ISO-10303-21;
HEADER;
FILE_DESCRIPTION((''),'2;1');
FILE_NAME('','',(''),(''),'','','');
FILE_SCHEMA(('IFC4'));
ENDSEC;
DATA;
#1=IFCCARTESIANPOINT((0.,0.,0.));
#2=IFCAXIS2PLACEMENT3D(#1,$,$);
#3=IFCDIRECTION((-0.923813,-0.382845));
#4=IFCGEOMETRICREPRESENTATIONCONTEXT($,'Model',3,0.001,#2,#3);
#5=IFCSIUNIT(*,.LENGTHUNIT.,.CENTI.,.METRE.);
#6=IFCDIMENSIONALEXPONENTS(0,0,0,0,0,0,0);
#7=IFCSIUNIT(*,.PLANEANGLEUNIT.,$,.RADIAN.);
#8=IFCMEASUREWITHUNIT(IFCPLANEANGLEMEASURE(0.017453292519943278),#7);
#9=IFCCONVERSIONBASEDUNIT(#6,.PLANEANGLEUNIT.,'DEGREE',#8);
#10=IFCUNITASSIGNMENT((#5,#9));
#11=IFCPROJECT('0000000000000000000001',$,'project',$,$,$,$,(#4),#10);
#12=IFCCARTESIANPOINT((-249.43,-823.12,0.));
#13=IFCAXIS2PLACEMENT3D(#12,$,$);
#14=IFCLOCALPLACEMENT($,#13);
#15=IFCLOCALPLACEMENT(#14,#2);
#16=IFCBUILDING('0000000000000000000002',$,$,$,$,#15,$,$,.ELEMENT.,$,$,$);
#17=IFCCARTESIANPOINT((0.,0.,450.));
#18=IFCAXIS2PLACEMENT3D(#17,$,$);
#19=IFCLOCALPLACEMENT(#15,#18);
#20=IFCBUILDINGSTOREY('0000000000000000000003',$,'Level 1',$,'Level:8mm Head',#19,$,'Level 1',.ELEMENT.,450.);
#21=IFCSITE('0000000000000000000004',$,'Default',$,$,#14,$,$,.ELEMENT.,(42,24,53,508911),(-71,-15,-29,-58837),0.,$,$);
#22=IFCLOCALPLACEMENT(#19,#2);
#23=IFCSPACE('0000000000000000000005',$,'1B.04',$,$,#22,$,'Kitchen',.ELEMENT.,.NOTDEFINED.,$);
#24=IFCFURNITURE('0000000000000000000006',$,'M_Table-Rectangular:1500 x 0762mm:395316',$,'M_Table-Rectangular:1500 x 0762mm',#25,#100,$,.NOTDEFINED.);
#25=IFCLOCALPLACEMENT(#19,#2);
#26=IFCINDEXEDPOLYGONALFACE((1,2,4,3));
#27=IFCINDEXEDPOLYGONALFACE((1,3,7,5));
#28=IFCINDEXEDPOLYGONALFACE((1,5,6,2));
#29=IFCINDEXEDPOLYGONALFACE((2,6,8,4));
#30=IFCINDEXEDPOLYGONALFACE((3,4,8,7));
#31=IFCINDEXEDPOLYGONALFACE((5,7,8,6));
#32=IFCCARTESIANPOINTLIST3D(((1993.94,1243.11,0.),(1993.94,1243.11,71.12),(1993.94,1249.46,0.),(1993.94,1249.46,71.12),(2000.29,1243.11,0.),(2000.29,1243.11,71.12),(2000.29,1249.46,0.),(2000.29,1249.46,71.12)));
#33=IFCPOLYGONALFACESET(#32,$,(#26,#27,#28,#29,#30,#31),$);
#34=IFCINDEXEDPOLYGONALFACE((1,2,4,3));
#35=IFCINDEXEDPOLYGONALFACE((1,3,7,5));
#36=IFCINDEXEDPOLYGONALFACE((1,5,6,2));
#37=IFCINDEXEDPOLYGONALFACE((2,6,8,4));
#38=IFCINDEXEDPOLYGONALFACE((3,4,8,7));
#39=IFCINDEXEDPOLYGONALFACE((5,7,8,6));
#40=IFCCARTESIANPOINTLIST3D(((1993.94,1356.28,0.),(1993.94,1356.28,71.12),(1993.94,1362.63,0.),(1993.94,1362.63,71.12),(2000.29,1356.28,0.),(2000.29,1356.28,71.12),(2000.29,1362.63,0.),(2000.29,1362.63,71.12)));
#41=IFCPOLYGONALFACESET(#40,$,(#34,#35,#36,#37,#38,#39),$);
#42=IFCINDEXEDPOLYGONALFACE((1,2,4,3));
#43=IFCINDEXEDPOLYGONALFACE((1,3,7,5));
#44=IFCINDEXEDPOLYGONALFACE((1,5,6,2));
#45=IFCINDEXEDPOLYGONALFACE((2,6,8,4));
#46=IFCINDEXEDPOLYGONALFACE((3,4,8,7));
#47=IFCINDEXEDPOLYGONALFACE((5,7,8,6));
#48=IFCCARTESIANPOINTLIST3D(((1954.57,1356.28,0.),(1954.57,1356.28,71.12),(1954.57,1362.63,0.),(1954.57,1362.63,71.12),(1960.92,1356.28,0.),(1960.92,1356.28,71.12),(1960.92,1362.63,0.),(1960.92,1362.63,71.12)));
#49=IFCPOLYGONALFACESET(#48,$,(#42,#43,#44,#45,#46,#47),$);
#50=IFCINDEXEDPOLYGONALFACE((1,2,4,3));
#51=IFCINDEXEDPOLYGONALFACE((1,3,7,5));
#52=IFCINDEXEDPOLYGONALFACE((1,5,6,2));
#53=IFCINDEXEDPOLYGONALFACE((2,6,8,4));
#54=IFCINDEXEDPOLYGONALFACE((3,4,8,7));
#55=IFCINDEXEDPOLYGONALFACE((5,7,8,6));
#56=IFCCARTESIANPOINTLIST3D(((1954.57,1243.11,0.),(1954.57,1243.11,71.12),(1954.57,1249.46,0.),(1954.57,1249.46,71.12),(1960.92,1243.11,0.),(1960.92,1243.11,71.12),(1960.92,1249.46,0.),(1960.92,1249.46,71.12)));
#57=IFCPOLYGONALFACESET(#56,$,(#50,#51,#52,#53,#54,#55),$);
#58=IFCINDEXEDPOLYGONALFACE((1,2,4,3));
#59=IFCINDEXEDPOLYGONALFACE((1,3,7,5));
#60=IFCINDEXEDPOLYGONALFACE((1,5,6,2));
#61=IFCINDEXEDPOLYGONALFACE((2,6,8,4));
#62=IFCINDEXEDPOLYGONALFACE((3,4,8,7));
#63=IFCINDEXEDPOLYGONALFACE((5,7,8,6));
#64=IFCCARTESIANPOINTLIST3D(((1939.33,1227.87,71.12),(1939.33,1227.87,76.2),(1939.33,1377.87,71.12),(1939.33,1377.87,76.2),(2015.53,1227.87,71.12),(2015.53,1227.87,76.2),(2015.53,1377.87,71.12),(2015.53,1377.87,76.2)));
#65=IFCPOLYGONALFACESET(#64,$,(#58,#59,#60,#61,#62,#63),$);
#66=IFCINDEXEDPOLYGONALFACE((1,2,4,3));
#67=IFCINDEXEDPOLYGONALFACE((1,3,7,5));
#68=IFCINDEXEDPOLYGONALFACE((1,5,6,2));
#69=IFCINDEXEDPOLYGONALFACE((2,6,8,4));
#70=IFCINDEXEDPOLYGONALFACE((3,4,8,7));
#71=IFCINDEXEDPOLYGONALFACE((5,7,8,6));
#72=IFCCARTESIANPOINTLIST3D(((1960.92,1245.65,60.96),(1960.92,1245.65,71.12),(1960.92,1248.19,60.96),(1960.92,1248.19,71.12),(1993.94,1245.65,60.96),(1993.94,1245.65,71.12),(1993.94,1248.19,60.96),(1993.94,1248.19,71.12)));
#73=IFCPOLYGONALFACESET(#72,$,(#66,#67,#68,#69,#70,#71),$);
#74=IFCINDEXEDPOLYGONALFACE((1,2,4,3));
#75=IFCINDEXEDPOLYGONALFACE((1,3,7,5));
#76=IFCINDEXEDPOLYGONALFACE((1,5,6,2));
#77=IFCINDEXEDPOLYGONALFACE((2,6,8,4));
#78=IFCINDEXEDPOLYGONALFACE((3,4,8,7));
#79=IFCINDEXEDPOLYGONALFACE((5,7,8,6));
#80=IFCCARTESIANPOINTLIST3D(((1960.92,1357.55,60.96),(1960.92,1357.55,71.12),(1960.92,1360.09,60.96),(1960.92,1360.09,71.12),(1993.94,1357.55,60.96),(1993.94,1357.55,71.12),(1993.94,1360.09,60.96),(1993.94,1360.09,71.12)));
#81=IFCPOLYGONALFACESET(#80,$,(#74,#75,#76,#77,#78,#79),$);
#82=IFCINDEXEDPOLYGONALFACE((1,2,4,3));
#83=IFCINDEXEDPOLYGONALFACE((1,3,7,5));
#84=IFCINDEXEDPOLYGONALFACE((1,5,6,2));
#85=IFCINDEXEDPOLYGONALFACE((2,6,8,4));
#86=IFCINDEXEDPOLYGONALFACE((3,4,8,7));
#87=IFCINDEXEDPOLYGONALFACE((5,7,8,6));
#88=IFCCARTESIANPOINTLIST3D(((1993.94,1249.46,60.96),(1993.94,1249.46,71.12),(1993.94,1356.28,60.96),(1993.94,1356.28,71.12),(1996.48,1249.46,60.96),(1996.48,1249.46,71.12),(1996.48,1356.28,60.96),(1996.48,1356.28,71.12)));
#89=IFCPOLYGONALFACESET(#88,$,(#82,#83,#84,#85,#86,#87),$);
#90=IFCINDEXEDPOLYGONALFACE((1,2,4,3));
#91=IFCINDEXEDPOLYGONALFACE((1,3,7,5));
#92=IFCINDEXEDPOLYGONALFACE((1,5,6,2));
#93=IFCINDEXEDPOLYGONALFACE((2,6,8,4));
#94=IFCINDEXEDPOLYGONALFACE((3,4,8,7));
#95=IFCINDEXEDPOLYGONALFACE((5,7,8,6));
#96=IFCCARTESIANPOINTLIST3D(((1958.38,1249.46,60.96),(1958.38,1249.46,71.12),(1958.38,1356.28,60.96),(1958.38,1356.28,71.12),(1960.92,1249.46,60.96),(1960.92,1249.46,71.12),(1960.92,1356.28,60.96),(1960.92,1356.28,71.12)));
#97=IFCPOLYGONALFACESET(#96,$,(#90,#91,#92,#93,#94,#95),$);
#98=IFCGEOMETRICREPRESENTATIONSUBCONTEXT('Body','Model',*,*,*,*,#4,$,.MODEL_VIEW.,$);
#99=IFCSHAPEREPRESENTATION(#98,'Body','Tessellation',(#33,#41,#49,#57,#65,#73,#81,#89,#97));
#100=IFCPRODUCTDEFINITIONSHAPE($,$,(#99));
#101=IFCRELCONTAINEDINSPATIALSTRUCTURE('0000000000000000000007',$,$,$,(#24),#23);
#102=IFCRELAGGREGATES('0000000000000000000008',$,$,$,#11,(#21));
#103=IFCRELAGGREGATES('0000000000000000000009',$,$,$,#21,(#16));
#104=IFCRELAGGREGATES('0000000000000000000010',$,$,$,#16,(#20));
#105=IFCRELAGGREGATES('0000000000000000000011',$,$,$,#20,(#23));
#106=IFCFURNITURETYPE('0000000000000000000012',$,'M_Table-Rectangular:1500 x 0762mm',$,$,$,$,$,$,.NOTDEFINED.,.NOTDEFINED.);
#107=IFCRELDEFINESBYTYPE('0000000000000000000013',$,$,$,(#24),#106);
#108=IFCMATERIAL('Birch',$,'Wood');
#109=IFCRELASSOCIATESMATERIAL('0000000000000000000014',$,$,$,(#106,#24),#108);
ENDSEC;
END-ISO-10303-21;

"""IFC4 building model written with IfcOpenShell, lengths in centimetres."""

from ifc_helpers import new_model, entity, si_unit, converted_unit, direction, frame, origin, place, context, subcontext, project, spatial, indexed_curve, outline, extrude, source, transform, mapped, material, type_object, type_shapes, element, save


model = new_model("IFC4")

# Units and contexts
model_context = context("Model", 3, precision=0.001, world=origin(), true_north=direction((-0.923813, -0.382845)))
body_context = subcontext(model_context, "Body", "Model", "MODEL_VIEW")
ifc_project = project(units=[si_unit("LENGTHUNIT", "METRE", prefix="CENTI"), converted_unit("PLANEANGLEUNIT", "DEGREE", entity("IfcPlaneAngleMeasure", 0.017453292519943278), si_unit("PLANEANGLEUNIT", "RADIAN"), dimensions=[0, 0, 0, 0, 0, 0, 0])], contexts=[model_context])

# Site, building, storey
site_placement = place(None, frame((-249.43, -823.12, 0.0)))
site = spatial("IfcSite", under=ifc_project, at=site_placement, Name="Default", CompositionType="ELEMENT", RefLatitude=(42, 24, 53, 508911), RefLongitude=(-71, -15, -29, -58837), RefElevation=0.0)
building_placement = place(site_placement, origin())
building = spatial("IfcBuilding", under=site, at=building_placement, CompositionType="ELEMENT")
storey_placement = place(building_placement, frame((0.0, 0.0, 450.0)))
storey = spatial("IfcBuildingStorey", under=building, at=storey_placement, Name="Level 1", ObjectType="Level:8mm Head", LongName="Level 1", CompositionType="ELEMENT", Elevation=450.0)

# Shared definitions
space_placement = place(storey_placement, origin())
space = spatial("IfcSpace", under=storey, at=space_placement, Name="1B.04", LongName="Kitchen", CompositionType="ELEMENT", PredefinedType="NOTDEFINED")

# Furniture
ifc_material_1 = material(Name="Birch", Category="Wood")
furniture_type_1 = type_object("IfcFurnitureType", Name="M_Table-Rectangular:1500 x 0762mm", AssemblyPlace="NOTDEFINED", PredefinedType="NOTDEFINED", material=ifc_material_1)
shared_shape_1 = source(origin(), body_context, "Body", "SweptSolid", [
    extrude(outline(indexed_curve([(-3.18, -3.18), (3.18, -3.18), (3.18, 3.18), (-3.18, 3.18), (-3.18, -3.18)], self_intersect=False)), frame((56.58, 19.69, 0.0), z_axis=(0.0, 0.0, 1.0), x_axis=(0.0, -1.0, 0.0)), (0.0, 0.0, 1.0), 71.12),
    extrude(outline(indexed_curve([(-3.17, -3.18), (3.17, -3.18), (3.17, 3.18), (-3.17, 3.18), (-3.17, -3.18)], self_intersect=False)), frame((-56.58, 19.69, 0.0), z_axis=(0.0, 0.0, 1.0), x_axis=(-1.0, 0.0, 0.0)), (0.0, 0.0, 1.0), 71.12),
    extrude(outline(indexed_curve([(-3.17, -3.17), (3.17, -3.17), (3.17, 3.17), (-3.17, 3.17), (-3.17, -3.17)], self_intersect=False)), frame((-56.58, -19.69, 0.0), z_axis=(0.0, 0.0, 1.0), x_axis=(0.0, 1.0, 0.0)), (0.0, 0.0, 1.0), 71.12),
    extrude(outline(indexed_curve([(-3.18, -3.17), (3.18, -3.17), (3.18, 3.18), (-3.18, 3.18), (-3.18, -3.17)], self_intersect=False)), frame((56.58, -19.69, 0.0)), (0.0, 0.0, 1.0), 71.12),
    extrude(outline(indexed_curve([(-75.0, -38.1), (75.0, -38.1), (75.0, 38.1), (-75.0, 38.1), (-75.0, -38.1)], self_intersect=False)), frame((0.0, 0.0, 71.12), z_axis=(0.0, 0.0, 1.0), x_axis=(-1.0, 0.0, 0.0)), (0.0, 0.0, 1.0), 5.08),
    extrude(outline(indexed_curve([(-1.27, -16.51), (1.27, -16.51), (1.27, 16.51), (-1.27, 16.51), (-1.27, -16.51)], self_intersect=False)), frame((55.95, 0.0, 60.96)), (0.0, 0.0, 1.0), 10.16),
    extrude(outline(indexed_curve([(-16.51, -1.27), (16.51, -1.27), (16.51, 1.27), (-16.51, 1.27), (-16.51, -1.27)], self_intersect=False)), frame((-55.95, 0.0, 60.96), z_axis=(0.0, 0.0, 1.0), x_axis=(0.0, 1.0, 0.0)), (0.0, 0.0, 1.0), 10.16),
    extrude(outline(indexed_curve([(-53.41, -1.27), (53.41, -1.27), (53.41, 1.27), (-53.41, 1.27), (-53.41, -1.27)], self_intersect=False)), frame((0.0, 17.78, 60.96), z_axis=(0.0, 0.0, 1.0), x_axis=(-1.0, 0.0, 0.0)), (0.0, 0.0, 1.0), 10.16),
    extrude(outline(indexed_curve([(-1.27, -53.41), (1.27, -53.41), (1.27, 53.41), (-1.27, 53.41), (-1.27, -53.41)], self_intersect=False)), frame((0.0, -17.78, 60.96), z_axis=(0.0, 0.0, 1.0), x_axis=(0.0, 1.0, 0.0)), (0.0, 0.0, 1.0), 10.16),
])
type_shapes(furniture_type_1, [shared_shape_1])
furniture_1_placement = place(space_placement, frame((1977.43, 1302.87, 0.0), z_axis=(0.0, 0.0, 1.0), x_axis=(0.0, -1.0, 0.0)))
element("IfcFurniture", 1, at=furniture_1_placement, inside=space, type_object=furniture_type_1, material=ifc_material_1, Name="M_Table-Rectangular:1500 x 0762mm:395316", ObjectType="M_Table-Rectangular:1500 x 0762mm", PredefinedType="NOTDEFINED", context=body_context, shape_type="MappedRepresentation", body=[
    mapped(shared_shape_1, transform((0.0, 0.0, 0.0), scale=1.0)),
])

save(model, "model.ifc")
